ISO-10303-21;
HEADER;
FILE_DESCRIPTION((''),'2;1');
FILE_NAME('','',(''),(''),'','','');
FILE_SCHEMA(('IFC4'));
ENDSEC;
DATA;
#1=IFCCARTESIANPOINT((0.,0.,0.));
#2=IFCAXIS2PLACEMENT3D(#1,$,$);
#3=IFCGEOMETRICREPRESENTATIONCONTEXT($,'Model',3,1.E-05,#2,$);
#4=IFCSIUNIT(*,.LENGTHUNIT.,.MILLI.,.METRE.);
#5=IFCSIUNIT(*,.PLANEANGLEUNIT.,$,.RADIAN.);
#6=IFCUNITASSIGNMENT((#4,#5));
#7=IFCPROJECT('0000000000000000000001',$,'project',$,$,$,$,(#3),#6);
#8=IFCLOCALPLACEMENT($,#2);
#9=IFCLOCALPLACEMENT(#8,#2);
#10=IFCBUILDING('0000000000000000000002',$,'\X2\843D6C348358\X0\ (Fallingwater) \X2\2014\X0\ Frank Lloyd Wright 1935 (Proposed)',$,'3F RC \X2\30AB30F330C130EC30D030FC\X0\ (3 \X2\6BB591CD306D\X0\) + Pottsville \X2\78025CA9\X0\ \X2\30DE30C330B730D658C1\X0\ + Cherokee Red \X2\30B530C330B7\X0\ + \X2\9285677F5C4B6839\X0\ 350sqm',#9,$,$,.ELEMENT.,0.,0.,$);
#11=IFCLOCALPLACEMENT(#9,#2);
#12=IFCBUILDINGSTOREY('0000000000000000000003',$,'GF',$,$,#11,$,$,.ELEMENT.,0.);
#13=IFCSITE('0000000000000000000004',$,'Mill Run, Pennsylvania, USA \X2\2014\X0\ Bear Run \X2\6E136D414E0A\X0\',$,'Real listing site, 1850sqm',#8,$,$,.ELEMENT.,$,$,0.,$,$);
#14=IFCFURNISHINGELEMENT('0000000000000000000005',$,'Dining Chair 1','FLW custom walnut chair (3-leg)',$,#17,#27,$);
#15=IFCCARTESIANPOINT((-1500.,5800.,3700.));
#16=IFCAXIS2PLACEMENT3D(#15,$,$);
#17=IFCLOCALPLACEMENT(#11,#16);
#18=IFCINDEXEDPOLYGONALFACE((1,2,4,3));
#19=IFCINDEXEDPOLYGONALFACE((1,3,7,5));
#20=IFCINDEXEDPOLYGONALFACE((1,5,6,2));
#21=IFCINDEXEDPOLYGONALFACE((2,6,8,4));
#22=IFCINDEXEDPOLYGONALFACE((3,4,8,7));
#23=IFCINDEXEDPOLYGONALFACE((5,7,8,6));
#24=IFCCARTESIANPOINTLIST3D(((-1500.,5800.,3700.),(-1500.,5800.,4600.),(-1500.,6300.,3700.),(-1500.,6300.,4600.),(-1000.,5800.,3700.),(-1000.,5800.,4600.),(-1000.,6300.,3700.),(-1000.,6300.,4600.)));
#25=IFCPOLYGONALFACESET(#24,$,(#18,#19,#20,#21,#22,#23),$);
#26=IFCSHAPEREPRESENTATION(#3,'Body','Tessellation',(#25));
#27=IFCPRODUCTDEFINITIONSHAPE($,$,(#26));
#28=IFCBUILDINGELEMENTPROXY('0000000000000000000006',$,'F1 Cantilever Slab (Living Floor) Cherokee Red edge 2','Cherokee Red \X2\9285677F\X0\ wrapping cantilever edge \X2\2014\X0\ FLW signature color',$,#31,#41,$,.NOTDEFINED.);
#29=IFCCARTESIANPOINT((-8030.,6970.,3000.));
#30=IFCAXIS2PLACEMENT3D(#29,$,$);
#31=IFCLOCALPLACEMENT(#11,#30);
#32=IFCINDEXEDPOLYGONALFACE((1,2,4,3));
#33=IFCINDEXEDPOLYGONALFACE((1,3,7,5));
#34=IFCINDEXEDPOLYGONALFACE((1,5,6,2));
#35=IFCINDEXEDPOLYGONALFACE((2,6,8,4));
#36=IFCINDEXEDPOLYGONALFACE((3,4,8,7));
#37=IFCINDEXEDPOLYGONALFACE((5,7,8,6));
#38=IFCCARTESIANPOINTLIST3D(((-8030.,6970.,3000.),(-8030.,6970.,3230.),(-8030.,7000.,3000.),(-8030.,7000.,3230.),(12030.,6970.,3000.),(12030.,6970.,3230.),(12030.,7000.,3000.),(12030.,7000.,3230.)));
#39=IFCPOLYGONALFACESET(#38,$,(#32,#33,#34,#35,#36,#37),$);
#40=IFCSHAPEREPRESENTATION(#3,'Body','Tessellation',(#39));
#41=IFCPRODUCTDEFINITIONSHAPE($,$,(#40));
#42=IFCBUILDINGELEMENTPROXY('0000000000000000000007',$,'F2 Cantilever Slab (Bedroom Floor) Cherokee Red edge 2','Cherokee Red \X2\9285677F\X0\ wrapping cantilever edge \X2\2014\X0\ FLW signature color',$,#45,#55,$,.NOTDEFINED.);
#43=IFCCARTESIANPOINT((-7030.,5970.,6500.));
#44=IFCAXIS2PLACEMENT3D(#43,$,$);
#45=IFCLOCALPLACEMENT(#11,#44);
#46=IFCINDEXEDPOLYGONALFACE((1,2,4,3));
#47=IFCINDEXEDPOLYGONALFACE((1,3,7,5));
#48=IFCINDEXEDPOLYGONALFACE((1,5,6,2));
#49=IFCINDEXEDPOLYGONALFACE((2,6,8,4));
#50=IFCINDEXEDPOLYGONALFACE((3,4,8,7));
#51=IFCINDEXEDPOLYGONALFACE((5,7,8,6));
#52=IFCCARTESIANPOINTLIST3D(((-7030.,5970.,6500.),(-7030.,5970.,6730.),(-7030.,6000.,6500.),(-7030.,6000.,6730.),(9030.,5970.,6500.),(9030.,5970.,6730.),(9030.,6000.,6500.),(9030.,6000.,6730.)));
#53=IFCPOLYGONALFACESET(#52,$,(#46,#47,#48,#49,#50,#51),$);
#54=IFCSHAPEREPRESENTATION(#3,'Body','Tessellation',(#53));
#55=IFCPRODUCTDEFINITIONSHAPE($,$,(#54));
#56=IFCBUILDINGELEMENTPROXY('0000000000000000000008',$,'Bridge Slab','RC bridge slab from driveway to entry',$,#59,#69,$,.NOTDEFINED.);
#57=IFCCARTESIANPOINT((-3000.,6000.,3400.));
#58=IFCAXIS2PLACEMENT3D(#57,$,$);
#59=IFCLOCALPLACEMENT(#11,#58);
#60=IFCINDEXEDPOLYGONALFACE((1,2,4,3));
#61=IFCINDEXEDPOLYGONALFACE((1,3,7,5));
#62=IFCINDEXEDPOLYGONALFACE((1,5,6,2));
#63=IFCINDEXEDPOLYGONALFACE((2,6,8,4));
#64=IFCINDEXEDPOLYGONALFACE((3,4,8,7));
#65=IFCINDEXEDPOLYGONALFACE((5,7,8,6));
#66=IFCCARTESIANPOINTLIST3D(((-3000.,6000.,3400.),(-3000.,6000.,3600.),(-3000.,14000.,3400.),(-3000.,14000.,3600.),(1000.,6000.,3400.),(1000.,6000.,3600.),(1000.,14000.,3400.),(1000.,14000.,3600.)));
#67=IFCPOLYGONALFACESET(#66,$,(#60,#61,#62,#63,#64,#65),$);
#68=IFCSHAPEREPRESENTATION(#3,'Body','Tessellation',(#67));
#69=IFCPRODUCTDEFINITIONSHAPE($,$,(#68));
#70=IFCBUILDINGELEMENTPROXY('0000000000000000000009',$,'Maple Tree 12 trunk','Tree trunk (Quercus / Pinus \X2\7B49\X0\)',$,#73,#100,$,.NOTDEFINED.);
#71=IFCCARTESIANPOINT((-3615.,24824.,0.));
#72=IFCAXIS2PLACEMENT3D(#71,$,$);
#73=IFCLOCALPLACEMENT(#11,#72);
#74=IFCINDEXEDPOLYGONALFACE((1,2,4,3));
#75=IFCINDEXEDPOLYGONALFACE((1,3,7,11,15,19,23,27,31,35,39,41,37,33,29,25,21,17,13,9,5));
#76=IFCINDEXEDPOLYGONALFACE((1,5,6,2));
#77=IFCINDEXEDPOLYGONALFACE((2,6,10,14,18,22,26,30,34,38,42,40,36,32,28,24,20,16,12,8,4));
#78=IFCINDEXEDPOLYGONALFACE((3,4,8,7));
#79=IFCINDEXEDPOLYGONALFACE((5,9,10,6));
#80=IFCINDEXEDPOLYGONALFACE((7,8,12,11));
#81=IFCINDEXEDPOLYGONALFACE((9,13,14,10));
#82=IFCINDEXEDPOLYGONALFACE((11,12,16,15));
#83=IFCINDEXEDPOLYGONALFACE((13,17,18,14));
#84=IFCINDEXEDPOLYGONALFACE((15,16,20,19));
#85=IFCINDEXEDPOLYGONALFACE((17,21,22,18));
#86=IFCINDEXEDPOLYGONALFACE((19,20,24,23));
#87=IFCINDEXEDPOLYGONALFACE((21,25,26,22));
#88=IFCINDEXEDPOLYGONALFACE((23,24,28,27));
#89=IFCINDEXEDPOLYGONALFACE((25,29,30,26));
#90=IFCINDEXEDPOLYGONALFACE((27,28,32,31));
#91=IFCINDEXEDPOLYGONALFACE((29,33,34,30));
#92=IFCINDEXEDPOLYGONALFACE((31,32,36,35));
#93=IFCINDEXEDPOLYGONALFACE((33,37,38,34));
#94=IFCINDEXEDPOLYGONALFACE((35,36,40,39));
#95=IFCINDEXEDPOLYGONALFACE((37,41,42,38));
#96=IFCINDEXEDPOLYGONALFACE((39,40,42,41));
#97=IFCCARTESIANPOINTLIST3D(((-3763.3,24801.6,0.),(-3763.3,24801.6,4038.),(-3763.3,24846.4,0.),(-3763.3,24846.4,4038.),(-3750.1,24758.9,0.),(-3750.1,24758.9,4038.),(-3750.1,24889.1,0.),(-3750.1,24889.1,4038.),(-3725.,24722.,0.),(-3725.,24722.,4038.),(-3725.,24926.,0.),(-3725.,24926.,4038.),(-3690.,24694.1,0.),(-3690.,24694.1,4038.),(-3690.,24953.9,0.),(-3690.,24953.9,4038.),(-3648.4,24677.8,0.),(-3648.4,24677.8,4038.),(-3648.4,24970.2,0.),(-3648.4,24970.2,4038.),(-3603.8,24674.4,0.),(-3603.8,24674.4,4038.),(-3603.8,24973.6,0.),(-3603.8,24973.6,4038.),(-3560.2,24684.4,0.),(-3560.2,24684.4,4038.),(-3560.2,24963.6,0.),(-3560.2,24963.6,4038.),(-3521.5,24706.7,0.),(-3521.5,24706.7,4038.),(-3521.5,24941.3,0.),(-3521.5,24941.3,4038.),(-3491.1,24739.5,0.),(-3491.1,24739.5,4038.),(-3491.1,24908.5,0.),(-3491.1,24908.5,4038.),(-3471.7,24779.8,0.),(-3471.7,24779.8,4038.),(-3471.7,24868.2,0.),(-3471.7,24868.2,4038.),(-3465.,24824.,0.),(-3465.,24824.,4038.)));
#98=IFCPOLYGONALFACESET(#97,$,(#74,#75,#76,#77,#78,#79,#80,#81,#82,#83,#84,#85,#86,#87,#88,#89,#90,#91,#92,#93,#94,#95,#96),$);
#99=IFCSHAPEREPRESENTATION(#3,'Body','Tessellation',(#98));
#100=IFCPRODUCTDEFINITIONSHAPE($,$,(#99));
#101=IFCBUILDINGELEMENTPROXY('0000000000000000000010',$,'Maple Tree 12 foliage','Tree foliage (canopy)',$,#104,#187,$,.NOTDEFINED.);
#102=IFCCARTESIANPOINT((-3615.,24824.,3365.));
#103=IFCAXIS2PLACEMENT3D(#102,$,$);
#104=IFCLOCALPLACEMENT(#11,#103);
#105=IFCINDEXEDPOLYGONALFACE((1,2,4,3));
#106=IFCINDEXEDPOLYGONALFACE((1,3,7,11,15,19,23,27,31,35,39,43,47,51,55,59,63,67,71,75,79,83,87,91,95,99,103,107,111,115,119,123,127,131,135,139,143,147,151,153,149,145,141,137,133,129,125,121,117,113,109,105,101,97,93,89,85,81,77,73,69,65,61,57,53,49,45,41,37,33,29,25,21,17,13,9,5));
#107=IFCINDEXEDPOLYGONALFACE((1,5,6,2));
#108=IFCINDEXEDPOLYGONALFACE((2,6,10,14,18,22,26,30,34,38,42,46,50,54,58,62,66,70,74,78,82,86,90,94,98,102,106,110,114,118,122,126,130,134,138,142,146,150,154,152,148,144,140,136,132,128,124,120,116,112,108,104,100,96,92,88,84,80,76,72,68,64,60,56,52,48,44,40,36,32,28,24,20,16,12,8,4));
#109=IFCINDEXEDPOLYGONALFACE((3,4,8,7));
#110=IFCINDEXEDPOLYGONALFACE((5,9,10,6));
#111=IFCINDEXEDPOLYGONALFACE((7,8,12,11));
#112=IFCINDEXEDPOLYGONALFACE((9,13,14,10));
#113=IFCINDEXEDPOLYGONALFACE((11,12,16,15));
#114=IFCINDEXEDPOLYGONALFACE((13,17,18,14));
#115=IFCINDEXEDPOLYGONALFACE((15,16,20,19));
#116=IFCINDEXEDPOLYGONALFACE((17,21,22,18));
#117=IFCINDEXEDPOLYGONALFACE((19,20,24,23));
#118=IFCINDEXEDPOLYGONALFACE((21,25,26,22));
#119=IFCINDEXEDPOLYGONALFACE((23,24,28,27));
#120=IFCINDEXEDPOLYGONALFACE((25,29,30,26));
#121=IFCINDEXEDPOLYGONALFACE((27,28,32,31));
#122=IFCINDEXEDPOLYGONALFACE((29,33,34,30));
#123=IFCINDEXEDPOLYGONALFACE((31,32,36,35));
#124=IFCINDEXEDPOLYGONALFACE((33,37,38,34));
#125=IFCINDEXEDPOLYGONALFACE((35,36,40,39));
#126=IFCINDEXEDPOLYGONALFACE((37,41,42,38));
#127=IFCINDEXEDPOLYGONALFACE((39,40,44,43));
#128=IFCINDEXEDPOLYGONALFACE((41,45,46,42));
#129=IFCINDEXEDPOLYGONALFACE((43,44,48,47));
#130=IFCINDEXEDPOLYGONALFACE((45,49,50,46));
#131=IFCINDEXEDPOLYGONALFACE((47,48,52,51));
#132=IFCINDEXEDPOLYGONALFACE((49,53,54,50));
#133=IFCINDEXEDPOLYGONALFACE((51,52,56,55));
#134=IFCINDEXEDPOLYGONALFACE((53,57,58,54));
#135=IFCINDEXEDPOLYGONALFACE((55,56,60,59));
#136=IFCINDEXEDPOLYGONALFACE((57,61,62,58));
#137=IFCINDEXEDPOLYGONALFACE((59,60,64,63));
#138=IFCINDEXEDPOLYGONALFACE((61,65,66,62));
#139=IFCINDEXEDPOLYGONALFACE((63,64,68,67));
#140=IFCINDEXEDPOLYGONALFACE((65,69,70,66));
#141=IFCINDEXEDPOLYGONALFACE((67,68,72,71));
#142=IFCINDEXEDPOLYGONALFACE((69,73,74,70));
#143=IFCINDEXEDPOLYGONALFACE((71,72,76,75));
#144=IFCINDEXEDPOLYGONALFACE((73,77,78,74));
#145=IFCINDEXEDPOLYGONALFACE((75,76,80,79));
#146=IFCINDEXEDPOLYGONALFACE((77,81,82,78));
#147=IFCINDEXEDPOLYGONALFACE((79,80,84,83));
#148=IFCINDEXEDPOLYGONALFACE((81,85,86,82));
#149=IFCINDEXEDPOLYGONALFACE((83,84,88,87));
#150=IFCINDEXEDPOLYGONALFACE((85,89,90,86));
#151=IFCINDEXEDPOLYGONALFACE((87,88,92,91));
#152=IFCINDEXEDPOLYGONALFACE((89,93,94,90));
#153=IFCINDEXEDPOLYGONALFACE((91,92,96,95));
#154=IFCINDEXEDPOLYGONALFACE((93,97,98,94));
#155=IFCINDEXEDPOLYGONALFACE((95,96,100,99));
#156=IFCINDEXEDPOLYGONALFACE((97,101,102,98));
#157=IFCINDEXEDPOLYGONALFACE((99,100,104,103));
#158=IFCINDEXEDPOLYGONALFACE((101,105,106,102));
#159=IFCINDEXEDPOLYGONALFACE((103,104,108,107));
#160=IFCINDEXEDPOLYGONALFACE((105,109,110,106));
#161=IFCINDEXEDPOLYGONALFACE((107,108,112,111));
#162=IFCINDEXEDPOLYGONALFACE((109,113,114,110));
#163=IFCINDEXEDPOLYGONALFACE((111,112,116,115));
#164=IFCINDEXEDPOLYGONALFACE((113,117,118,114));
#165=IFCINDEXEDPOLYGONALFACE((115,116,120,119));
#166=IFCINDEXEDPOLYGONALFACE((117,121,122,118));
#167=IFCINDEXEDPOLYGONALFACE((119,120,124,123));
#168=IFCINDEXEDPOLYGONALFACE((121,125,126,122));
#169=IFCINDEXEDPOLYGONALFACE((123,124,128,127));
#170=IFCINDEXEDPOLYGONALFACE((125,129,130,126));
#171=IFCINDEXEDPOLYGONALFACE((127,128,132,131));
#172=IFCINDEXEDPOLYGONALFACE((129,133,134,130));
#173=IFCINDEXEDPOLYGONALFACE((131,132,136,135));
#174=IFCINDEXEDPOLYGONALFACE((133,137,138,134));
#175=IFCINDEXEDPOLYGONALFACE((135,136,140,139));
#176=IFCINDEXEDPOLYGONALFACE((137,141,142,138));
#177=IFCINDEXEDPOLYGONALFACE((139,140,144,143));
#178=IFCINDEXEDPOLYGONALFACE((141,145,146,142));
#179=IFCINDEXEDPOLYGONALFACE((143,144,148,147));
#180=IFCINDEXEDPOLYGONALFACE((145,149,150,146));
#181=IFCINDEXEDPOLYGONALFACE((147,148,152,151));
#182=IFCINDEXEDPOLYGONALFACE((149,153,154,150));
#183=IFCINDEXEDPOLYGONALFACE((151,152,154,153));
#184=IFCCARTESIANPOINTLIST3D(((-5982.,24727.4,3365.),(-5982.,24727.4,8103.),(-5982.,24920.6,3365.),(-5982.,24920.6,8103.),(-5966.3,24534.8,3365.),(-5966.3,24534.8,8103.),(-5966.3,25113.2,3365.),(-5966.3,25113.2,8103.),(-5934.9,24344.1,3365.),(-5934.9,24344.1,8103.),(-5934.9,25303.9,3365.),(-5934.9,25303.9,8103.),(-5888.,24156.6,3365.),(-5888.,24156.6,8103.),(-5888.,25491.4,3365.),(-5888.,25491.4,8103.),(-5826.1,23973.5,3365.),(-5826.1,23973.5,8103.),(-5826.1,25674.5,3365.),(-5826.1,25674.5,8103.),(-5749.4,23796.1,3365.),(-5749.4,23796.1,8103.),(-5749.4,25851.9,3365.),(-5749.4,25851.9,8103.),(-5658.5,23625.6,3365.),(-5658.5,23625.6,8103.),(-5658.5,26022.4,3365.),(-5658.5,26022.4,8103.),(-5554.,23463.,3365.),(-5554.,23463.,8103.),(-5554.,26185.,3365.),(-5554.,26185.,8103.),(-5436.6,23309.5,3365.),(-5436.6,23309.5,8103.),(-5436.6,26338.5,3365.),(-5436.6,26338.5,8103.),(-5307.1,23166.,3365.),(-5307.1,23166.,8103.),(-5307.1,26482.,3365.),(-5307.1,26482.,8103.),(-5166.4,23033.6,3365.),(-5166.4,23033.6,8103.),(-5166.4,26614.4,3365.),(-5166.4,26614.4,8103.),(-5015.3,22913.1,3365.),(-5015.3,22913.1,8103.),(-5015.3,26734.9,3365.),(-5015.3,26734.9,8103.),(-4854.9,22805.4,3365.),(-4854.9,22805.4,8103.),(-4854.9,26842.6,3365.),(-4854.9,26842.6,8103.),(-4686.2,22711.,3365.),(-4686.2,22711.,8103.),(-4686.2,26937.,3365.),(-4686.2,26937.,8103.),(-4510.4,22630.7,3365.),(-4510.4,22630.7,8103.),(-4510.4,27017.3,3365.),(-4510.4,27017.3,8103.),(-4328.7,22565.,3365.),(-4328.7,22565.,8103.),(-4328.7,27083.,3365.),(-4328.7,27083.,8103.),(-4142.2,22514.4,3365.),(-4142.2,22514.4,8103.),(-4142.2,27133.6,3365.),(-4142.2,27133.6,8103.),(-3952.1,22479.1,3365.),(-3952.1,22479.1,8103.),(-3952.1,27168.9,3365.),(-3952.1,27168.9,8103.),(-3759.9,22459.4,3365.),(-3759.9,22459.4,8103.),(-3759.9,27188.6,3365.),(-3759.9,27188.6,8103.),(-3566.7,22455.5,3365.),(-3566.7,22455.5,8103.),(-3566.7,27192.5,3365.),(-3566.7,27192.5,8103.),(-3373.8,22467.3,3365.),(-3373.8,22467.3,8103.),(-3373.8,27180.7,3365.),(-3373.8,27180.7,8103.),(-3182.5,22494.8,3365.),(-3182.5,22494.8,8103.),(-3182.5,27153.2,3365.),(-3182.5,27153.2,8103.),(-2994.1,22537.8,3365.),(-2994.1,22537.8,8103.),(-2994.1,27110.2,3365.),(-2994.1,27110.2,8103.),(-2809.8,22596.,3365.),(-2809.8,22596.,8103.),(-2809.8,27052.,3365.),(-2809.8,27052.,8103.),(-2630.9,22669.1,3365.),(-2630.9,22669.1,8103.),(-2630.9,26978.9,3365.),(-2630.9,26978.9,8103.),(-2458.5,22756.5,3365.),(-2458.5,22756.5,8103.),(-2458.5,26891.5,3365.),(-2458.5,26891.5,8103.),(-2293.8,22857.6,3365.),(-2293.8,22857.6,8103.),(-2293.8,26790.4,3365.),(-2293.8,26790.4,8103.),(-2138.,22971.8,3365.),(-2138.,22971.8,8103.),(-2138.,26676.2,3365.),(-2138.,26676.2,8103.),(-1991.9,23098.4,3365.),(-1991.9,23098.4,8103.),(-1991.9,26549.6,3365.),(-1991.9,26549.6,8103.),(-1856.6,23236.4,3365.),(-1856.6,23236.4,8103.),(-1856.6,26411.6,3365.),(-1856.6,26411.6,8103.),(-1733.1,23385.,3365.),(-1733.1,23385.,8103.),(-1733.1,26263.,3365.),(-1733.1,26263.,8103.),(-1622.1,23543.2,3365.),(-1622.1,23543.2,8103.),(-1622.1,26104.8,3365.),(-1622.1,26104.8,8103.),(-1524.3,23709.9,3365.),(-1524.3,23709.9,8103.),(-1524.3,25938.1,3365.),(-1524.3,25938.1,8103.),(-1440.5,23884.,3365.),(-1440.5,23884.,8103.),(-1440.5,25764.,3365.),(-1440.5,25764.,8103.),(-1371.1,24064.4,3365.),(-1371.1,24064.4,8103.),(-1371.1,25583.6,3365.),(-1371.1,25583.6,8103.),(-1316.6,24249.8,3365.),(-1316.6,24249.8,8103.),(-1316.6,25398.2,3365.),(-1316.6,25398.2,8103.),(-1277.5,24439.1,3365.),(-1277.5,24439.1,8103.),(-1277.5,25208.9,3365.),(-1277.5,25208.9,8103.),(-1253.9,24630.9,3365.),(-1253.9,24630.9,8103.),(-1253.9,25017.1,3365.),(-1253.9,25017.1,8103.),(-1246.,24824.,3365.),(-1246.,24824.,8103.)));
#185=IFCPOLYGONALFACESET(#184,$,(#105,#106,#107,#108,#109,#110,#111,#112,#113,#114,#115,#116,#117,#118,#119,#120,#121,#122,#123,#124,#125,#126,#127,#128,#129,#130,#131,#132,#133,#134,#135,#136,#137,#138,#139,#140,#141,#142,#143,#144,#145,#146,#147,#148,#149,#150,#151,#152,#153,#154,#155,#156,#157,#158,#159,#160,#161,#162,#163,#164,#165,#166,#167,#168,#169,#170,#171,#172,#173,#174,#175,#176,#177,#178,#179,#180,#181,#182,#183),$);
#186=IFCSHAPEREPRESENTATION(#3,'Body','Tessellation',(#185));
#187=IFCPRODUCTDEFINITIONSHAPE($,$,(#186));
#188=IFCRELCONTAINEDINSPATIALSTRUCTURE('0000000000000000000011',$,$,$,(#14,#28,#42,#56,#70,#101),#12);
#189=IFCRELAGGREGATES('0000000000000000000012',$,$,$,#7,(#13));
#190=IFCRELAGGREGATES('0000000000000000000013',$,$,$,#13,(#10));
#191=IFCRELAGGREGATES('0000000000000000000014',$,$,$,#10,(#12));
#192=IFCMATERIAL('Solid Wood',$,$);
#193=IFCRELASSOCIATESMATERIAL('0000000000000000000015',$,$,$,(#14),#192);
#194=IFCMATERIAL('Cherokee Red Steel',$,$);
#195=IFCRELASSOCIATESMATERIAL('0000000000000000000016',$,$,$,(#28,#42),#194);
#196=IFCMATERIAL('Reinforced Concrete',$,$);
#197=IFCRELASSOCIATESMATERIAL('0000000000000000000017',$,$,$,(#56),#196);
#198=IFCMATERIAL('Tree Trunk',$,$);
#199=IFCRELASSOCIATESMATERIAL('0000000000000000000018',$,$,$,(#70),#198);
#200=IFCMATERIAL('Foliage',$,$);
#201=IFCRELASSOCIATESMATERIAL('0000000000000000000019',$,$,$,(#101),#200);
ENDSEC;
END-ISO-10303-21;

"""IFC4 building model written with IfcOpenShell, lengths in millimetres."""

from ifc_helpers import new_model, si_unit, frame, frame_2d, origin, origin_2d, place, context, project, spatial, rectangle, circle, extrude, material, element, save


model = new_model("IFC4")

# Units and contexts
model_context = context("Model", 3, precision=1e-05, world=origin())
ifc_project = project(units=[si_unit("LENGTHUNIT", "METRE", prefix="MILLI"), si_unit("PLANEANGLEUNIT", "RADIAN")], contexts=[model_context])

# Site, building, storey
site_placement = place(None, origin())
site = spatial("IfcSite", under=ifc_project, at=site_placement, Name="Mill Run, Pennsylvania, USA — Bear Run 渓流上", ObjectType="Real listing site, 1850sqm", CompositionType="ELEMENT", RefElevation=0.0)
building_placement = place(site_placement, origin())
building = spatial("IfcBuilding", under=site, at=building_placement, Name="落水荘 (Fallingwater) — Frank Lloyd Wright 1935 (Proposed)", ObjectType="3F RC カンチレバー (3 段重ね) + Pottsville 砂岩 マッシブ壁 + Cherokee Red サッシ + 銅板屋根 350sqm", CompositionType="ELEMENT", ElevationOfRefHeight=0.0, ElevationOfTerrain=0.0)
storey_placement = place(building_placement, origin())
storey = spatial("IfcBuildingStorey", under=building, at=storey_placement, Name="GF", CompositionType="ELEMENT", Elevation=0.0)

# Shared definitions
ifc_material_1 = material(Name="Cherokee Red Steel")

# Furnishing element
ifc_material_2 = material(Name="Solid Wood")
furnishing_placement = place(storey_placement, frame((-1500.0, 5800.0, 3700.0)))
element("IfcFurnishingElement", 1, at=furnishing_placement, inside=storey, material=ifc_material_2, Name="Dining Chair 1", Description="FLW custom walnut chair (3-leg)", context=model_context, shape_type="SweptSolid", body=[
    extrude(rectangle(XDim=500.0, YDim=500.0, at=frame_2d((250.0, 250.0))), frame((-1500.0, 5800.0, 3700.0)), (0.0, 0.0, 1.0), 900.0),
])

# Building element proxies
proxy_1_placement = place(storey_placement, frame((-8030.0, 6970.0, 3000.0)))
element("IfcBuildingElementProxy", 2, at=proxy_1_placement, inside=storey, material=ifc_material_1, Name="F1 Cantilever Slab (Living Floor) Cherokee Red edge 2", Description="Cherokee Red 銅板 wrapping cantilever edge — FLW signature color", PredefinedType="NOTDEFINED", context=model_context, shape_type="SweptSolid", body=[
    extrude(rectangle(XDim=20060.0, YDim=30.0, at=frame_2d((10030.0, 15.0))), frame((-8030.0, 6970.0, 3000.0)), (0.0, 0.0, 1.0), 230.0),
])
proxy_2_placement = place(storey_placement, frame((-7030.0, 5970.0, 6500.0)))
element("IfcBuildingElementProxy", 3, at=proxy_2_placement, inside=storey, material=ifc_material_1, Name="F2 Cantilever Slab (Bedroom Floor) Cherokee Red edge 2", Description="Cherokee Red 銅板 wrapping cantilever edge — FLW signature color", PredefinedType="NOTDEFINED", context=model_context, shape_type="SweptSolid", body=[
    extrude(rectangle(XDim=16060.0, YDim=30.0, at=frame_2d((8030.0, 15.0))), frame((-7030.0, 5970.0, 6500.0)), (0.0, 0.0, 1.0), 230.0),
])
ifc_material_3 = material(Name="Reinforced Concrete")
proxy_3_placement = place(storey_placement, frame((-3000.0, 6000.0, 3400.0)))
element("IfcBuildingElementProxy", 4, at=proxy_3_placement, inside=storey, material=ifc_material_3, Name="Bridge Slab", Description="RC bridge slab from driveway to entry", PredefinedType="NOTDEFINED", context=model_context, shape_type="SweptSolid", body=[
    extrude(rectangle(XDim=4000.0, YDim=8000.0, at=frame_2d((2000.0, 4000.0))), frame((-3000.0, 6000.0, 3400.0)), (0.0, 0.0, 1.0), 200.0),
])
ifc_material_4 = material(Name="Tree Trunk")
proxy_4_placement = place(storey_placement, frame((-3615.0, 24824.0, 0.0)))
element("IfcBuildingElementProxy", 5, at=proxy_4_placement, inside=storey, material=ifc_material_4, Name="Maple Tree 12 trunk", Description="Tree trunk (Quercus / Pinus 等)", PredefinedType="NOTDEFINED", context=model_context, shape_type="SweptSolid", body=[
    extrude(circle(Radius=150.0, at=origin_2d()), frame((-3615.0, 24824.0, 0.0)), (0.0, 0.0, 1.0), 4038.0),
])
ifc_material_5 = material(Name="Foliage")
proxy_5_placement = place(storey_placement, frame((-3615.0, 24824.0, 3365.0)))
element("IfcBuildingElementProxy", 6, at=proxy_5_placement, inside=storey, material=ifc_material_5, Name="Maple Tree 12 foliage", Description="Tree foliage (canopy)", PredefinedType="NOTDEFINED", context=model_context, shape_type="SweptSolid", body=[
    extrude(circle(Radius=2369.0, at=origin_2d()), frame((-3615.0, 24824.0, 3365.0)), (0.0, 0.0, 1.0), 4738.0),
])

save(model, "model.ifc")
